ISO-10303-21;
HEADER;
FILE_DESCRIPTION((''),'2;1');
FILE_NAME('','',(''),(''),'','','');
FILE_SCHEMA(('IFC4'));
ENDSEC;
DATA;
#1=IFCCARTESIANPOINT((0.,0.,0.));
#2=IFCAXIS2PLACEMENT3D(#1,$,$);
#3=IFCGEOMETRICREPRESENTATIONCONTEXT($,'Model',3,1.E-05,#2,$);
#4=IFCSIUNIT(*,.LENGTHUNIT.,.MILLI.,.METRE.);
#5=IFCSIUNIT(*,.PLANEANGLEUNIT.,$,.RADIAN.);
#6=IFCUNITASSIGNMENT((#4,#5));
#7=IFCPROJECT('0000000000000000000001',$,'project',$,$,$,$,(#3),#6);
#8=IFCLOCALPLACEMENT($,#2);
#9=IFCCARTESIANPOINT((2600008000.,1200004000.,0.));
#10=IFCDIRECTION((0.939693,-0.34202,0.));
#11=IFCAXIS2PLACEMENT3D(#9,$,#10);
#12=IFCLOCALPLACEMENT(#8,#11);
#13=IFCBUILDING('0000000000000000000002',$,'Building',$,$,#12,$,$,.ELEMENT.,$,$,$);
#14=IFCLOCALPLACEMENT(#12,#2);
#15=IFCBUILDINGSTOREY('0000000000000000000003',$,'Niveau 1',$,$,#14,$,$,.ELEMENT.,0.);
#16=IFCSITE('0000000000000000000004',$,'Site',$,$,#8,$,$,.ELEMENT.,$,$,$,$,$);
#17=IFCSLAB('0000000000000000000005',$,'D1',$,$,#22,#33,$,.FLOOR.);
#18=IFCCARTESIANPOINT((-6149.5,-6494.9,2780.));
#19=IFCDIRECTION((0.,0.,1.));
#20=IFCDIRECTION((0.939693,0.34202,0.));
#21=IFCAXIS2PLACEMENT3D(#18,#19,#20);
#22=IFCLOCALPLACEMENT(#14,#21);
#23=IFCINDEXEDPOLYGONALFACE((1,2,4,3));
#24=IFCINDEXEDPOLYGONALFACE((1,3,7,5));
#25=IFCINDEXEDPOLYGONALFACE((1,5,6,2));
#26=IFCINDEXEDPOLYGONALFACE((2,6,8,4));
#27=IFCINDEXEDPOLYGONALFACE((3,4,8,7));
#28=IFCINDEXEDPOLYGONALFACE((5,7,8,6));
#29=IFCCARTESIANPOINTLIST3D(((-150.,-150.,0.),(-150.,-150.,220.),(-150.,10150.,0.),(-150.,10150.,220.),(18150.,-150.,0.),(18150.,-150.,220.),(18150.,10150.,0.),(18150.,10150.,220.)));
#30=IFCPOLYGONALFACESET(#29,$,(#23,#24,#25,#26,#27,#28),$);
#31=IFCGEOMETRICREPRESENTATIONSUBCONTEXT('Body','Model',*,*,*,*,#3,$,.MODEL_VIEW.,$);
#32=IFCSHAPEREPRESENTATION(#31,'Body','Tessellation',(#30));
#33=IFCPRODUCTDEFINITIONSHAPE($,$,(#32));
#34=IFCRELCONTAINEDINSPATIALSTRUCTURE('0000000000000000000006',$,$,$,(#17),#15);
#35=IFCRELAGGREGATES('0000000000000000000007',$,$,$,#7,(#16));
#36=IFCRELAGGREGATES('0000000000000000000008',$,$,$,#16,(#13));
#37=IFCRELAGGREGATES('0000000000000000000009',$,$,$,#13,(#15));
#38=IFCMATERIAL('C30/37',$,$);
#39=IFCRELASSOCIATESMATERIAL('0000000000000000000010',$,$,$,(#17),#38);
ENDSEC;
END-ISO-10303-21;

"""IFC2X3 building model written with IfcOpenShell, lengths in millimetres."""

from ifc_helpers import new_model, si_unit, frame, origin, place, context, subcontext, project, spatial, polyline, outline, extrude, material, element, save


model = new_model("IFC2X3")

# Units and contexts
model_context = context("Model", 3, precision=1e-05, world=origin())
body_context = subcontext(model_context, "Body", "Model", "MODEL_VIEW")
ifc_project = project(units=[si_unit("LENGTHUNIT", "METRE", prefix="MILLI"), si_unit("PLANEANGLEUNIT", "RADIAN")], contexts=[model_context])

# Site, building, storey
site_placement = place(None, origin())
site = spatial("IfcSite", under=ifc_project, at=site_placement, Name="Site", CompositionType="ELEMENT")
building_placement = place(site_placement, frame((2600008000.0, 1200004000.0, 0.0), x_axis=(0.939693, -0.34202, 0.0)))
building = spatial("IfcBuilding", under=site, at=building_placement, Name="Building", CompositionType="ELEMENT")
storey_placement = place(building_placement, origin())
storey = spatial("IfcBuildingStorey", under=building, at=storey_placement, Name="Niveau 1", CompositionType="ELEMENT", Elevation=0.0)

# Shared definitions
ifc_material = material(Name="C30/37")

# Slab
slab_placement = place(storey_placement, frame((-6149.5, -6494.9, 2780.0), z_axis=(0.0, 0.0, 1.0), x_axis=(0.939693, 0.34202, 0.0)))
element("IfcSlab", 1, at=slab_placement, inside=storey, material=ifc_material, Name="D1", PredefinedType="FLOOR", context=body_context, shape_type="SweptSolid", body=[
    extrude(outline(polyline([(-150.0, -150.0), (18150.0, -150.0), (18150.0, 10150.0), (-150.0, 10150.0), (-150.0, -150.0)])), origin(), (0.0, 0.0, 1.0), 220.0),
])

save(model, "model.ifc")
